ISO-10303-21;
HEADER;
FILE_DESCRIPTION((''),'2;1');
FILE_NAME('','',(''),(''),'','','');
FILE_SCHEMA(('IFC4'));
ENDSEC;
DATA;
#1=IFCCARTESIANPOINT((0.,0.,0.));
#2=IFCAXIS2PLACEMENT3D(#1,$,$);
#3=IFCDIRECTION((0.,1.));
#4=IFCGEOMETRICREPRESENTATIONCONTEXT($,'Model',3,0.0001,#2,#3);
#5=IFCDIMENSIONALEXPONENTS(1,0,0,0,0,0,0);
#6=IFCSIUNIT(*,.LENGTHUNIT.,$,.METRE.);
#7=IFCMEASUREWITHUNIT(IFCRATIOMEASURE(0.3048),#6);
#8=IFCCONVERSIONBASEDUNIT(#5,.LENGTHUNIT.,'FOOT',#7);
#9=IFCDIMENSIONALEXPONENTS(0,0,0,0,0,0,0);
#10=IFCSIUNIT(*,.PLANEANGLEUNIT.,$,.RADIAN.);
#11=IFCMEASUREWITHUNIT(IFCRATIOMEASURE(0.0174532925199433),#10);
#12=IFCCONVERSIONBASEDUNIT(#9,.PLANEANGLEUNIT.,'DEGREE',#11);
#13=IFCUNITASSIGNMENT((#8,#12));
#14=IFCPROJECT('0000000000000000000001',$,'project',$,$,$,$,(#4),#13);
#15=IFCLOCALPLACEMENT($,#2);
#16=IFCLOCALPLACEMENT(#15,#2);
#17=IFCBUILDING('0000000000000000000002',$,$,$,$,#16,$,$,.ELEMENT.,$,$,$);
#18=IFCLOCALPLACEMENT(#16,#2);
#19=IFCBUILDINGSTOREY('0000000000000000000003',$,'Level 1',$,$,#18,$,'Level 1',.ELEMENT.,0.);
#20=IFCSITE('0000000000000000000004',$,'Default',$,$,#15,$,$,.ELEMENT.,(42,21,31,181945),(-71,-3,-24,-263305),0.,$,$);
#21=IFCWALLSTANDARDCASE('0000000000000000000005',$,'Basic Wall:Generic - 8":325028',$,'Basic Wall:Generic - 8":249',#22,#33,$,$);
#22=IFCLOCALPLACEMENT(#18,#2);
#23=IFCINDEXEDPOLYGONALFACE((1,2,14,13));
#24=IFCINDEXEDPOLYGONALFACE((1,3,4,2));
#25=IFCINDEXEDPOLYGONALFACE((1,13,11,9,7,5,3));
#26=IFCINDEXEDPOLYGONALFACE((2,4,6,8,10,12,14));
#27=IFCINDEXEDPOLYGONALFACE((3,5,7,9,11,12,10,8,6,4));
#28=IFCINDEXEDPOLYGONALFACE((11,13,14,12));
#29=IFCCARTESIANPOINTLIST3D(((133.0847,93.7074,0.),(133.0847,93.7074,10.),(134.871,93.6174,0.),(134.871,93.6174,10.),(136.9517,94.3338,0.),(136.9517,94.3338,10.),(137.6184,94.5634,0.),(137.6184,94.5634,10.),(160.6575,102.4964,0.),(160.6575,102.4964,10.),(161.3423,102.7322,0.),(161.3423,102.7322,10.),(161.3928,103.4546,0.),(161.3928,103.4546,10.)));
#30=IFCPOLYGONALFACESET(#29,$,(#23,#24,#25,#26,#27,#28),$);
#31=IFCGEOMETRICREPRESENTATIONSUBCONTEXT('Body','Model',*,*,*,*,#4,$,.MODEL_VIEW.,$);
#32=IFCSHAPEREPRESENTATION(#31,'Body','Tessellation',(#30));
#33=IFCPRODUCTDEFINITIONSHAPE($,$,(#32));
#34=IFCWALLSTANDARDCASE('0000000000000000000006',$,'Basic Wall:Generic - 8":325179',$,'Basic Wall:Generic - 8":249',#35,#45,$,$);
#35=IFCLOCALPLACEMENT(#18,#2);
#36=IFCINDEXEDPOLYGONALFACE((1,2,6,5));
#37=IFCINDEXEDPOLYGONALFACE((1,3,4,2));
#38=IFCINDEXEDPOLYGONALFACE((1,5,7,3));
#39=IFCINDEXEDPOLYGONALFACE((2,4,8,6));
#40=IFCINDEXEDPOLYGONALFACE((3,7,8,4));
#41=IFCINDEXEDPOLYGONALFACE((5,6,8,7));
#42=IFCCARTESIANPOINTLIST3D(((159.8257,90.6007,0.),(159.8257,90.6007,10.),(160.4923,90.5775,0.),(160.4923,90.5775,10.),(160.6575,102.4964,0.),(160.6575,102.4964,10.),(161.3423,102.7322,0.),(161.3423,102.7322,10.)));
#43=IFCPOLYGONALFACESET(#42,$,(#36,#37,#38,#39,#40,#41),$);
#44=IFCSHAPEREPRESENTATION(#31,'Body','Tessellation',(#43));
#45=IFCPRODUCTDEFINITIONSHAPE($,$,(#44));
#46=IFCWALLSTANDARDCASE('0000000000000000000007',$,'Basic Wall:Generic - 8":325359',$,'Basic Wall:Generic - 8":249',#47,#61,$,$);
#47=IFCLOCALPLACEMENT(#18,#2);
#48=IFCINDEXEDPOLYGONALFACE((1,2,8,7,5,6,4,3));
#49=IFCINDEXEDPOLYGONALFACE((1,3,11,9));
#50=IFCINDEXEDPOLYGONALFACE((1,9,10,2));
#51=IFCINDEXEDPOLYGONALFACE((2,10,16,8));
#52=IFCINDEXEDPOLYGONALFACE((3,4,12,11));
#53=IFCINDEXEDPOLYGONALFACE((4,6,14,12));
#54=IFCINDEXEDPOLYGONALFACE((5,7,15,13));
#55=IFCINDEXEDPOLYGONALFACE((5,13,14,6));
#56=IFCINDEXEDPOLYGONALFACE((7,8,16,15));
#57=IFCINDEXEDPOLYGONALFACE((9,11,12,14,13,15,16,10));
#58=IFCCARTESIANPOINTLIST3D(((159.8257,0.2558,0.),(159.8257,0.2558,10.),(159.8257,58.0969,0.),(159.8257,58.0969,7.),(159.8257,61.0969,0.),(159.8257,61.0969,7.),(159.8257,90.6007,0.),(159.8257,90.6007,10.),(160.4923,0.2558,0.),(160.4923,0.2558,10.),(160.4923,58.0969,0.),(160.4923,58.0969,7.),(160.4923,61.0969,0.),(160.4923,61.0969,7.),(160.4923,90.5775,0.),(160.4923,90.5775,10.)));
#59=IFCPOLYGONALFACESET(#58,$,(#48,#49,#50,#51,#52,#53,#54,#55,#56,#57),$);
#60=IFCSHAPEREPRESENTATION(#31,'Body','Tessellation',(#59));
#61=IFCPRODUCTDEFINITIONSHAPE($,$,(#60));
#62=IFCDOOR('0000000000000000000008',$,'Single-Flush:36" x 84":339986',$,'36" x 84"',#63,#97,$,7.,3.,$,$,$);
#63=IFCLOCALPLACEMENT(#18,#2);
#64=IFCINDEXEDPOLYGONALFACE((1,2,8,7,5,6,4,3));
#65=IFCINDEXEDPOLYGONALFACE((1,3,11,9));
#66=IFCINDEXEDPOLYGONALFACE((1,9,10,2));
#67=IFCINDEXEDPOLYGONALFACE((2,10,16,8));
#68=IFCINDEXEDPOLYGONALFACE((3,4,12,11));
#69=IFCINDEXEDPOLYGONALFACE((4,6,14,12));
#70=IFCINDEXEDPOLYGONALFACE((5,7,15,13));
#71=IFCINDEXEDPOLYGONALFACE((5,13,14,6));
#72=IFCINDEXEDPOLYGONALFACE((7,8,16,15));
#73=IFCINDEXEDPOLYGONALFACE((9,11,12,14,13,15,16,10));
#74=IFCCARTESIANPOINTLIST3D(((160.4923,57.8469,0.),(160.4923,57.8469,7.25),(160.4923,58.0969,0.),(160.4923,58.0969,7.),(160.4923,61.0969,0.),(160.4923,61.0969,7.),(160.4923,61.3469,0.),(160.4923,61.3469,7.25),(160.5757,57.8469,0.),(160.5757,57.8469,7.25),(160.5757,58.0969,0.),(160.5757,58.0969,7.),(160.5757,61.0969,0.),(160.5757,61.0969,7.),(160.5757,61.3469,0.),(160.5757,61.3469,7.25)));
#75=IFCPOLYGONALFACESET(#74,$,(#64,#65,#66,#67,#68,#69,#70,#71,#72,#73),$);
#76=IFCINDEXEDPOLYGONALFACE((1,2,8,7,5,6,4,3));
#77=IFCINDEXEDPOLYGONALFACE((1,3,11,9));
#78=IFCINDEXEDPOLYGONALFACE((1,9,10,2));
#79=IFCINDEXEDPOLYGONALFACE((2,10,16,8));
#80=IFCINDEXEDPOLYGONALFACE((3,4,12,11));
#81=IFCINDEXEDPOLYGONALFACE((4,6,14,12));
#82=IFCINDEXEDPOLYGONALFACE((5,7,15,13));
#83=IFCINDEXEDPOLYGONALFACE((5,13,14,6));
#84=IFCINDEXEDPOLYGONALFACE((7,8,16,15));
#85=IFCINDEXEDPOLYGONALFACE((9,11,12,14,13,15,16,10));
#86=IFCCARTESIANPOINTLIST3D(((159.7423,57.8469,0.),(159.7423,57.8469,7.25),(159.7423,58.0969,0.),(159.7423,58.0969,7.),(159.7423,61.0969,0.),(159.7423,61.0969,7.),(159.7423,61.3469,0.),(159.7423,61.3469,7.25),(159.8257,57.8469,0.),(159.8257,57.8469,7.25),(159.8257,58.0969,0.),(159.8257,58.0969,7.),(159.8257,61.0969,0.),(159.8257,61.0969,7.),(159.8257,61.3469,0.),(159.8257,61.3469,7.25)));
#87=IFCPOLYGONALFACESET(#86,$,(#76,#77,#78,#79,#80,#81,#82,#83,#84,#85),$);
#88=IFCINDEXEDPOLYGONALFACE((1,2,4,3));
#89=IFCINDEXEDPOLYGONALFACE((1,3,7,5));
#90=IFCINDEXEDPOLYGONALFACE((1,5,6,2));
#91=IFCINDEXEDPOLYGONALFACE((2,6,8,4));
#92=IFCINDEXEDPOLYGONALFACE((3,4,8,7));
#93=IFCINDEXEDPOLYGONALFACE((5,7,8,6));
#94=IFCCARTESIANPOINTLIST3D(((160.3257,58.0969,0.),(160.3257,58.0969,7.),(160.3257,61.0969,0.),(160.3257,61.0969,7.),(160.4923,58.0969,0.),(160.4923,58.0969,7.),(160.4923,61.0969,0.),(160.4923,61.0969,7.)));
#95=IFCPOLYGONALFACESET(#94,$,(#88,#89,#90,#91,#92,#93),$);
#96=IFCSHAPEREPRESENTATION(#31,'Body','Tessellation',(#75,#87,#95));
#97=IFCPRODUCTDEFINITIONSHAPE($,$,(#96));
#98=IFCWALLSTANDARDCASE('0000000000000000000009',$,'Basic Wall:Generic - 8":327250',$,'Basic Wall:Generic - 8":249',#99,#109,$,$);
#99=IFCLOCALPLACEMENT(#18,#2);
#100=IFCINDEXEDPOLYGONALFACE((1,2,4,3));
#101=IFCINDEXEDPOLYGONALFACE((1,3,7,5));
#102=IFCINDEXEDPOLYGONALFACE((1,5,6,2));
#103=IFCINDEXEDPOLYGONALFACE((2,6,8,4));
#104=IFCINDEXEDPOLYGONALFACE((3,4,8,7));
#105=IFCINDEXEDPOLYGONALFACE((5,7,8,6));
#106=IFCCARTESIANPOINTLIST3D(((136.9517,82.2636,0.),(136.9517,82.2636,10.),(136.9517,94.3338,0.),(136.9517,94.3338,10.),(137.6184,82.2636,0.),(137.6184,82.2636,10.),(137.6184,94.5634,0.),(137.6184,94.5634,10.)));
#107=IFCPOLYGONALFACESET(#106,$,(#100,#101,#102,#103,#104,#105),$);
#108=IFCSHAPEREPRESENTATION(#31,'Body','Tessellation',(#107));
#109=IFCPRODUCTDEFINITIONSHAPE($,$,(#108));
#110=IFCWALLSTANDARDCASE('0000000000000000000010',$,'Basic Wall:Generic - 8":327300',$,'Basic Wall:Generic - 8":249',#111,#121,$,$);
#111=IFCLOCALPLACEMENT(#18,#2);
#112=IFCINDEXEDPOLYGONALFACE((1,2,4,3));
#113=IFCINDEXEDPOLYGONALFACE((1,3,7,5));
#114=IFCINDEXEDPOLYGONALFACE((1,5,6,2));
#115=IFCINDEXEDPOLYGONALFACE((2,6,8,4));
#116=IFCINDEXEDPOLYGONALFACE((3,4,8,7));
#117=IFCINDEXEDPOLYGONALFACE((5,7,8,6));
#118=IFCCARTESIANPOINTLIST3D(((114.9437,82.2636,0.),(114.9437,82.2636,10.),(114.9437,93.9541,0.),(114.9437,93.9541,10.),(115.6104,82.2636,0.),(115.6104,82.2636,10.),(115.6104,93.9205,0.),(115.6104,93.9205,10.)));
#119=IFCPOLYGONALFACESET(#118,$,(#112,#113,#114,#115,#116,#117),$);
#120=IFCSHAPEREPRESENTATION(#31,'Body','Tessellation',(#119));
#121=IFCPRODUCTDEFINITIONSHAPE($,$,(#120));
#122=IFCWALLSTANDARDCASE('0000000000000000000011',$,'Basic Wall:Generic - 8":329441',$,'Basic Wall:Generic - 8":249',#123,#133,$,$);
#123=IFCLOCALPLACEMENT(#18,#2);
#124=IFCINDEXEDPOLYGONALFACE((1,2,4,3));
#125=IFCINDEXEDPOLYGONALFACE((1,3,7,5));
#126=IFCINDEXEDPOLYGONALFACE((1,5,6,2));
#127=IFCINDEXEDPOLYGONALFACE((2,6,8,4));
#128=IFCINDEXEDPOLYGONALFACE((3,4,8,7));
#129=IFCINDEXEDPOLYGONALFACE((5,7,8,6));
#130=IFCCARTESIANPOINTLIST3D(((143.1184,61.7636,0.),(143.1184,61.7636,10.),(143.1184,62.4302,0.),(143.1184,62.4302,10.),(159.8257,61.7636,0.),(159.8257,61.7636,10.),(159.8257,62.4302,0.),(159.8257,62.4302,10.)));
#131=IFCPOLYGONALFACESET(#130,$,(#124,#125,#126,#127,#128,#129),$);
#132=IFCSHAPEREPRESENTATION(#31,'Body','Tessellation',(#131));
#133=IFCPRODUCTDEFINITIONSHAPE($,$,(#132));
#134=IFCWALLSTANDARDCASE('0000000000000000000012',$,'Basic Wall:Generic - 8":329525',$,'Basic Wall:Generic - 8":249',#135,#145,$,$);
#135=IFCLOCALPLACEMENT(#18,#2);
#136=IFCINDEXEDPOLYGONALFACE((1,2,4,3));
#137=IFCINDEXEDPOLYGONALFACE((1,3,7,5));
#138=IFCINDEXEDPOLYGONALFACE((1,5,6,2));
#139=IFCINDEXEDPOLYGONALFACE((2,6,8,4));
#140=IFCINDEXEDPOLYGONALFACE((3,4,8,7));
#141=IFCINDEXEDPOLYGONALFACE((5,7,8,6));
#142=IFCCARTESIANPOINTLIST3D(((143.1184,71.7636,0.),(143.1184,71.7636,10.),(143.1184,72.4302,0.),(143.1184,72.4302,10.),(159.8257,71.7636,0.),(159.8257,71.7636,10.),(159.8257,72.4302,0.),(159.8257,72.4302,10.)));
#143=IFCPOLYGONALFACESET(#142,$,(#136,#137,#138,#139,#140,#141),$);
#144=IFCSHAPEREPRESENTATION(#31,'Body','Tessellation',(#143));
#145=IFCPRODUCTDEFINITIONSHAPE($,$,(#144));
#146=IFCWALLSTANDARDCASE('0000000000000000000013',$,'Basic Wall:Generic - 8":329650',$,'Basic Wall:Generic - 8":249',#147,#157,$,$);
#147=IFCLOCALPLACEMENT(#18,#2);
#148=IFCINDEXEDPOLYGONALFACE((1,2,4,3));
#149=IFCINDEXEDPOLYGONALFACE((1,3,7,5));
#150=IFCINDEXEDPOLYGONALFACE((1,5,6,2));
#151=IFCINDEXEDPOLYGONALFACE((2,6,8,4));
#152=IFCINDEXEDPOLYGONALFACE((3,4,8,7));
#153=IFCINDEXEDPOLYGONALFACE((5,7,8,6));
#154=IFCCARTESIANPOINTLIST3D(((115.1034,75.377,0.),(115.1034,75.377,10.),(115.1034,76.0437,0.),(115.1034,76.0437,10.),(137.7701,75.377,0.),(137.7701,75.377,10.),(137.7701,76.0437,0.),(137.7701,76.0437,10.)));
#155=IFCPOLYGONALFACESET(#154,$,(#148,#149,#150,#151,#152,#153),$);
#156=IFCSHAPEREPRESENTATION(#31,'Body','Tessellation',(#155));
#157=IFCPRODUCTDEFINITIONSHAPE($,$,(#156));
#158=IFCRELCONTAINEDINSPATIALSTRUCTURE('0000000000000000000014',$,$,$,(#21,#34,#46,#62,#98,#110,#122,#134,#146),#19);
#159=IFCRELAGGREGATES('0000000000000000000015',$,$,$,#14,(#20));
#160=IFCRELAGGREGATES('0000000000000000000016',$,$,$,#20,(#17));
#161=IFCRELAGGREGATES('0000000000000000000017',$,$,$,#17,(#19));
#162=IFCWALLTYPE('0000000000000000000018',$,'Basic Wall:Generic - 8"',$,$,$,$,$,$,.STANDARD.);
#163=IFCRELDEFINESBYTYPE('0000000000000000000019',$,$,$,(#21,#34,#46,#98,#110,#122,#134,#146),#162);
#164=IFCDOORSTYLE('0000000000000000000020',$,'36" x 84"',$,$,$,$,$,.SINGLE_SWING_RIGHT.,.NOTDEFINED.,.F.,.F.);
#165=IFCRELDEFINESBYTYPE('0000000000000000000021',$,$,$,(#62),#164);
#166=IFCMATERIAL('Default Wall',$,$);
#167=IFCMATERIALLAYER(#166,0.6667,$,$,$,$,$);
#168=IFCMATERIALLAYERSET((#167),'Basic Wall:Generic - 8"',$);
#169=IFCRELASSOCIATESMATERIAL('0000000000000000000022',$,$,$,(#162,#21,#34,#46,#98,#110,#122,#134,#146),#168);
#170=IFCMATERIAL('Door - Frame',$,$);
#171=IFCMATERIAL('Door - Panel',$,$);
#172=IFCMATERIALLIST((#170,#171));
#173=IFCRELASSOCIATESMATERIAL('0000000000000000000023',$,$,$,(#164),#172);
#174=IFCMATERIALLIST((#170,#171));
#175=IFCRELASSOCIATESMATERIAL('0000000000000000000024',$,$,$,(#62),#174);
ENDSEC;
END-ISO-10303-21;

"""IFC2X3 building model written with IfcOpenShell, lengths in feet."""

from ifc_helpers import new_model, entity, si_unit, converted_unit, direction, frame, frame_2d, origin, place, context, subcontext, project, spatial, polyline, rectangle, outline, extrude, source, transform, mapped, material, material_list, layer, layer_set, layer_usage, type_object, type_shapes, element, fill, save


model = new_model("IFC2X3")

# Units and contexts
model_context = context("Model", 3, precision=0.0001, world=origin(), true_north=direction((0.0, 1.0)))
body_context = subcontext(model_context, "Body", "Model", "MODEL_VIEW")
ifc_project = project(units=[converted_unit("LENGTHUNIT", "FOOT", entity("IfcRatioMeasure", 0.3048), si_unit("LENGTHUNIT", "METRE"), dimensions=[1, 0, 0, 0, 0, 0, 0]), converted_unit("PLANEANGLEUNIT", "DEGREE", entity("IfcRatioMeasure", 0.0174532925199433), si_unit("PLANEANGLEUNIT", "RADIAN"), dimensions=[0, 0, 0, 0, 0, 0, 0])], contexts=[model_context])

# Site, building, storey
site_placement = place(None, origin())
site = spatial("IfcSite", under=ifc_project, at=site_placement, Name="Default", CompositionType="ELEMENT", RefLatitude=(42, 21, 31, 181945), RefLongitude=(-71, -3, -24, -263305), RefElevation=0.0)
building_placement = place(site_placement, origin())
building = spatial("IfcBuilding", under=site, at=building_placement, CompositionType="ELEMENT")
storey_placement = place(building_placement, origin())
storey = spatial("IfcBuildingStorey", under=building, at=storey_placement, Name="Level 1", LongName="Level 1", CompositionType="ELEMENT", Elevation=0.0)

# Walls
ifc_material_1 = material(Name="Default Wall")
ifc_layer = layer(ifc_material_1, 0.6667)
ifc_layer_set = layer_set([ifc_layer], Name="Basic Wall:Generic - 8\"")
ifc_layer_usage_1 = layer_usage(ifc_layer_set, "AXIS2", "NEGATIVE", 0.3333)
wall_type = type_object("IfcWallType", Name="Basic Wall:Generic - 8\"", PredefinedType="STANDARD", material=ifc_layer_set)
wall_1_placement = place(storey_placement, frame((133.1933, 93.3922, 0.0), z_axis=(0.0, 0.0, 1.0), x_axis=(0.945519, 0.325568, 0.0)))
element("IfcWallStandardCase", 1, at=wall_1_placement, inside=storey, type_object=wall_type, material=ifc_layer_usage_1, Name="Basic Wall:Generic - 8\":325028", ObjectType="Basic Wall:Generic - 8\":249", context=body_context, shape_type="SweptSolid", body=[
    extrude(outline(polyline([(29.6562, -0.3333), (29.9392, 0.3333), (0.0, 0.3333), (1.6596, -0.3333), (3.8603, -0.3333), (4.5653, -0.3333), (28.9319, -0.3333), (29.6562, -0.3333)])), origin(), (0.0, 0.0, 1.0), 10.0),
])
ifc_layer_usage_2 = layer_usage(ifc_layer_set, "AXIS2", "NEGATIVE", 0.3333)
wall_2_placement = place(storey_placement, frame((161.0097, 102.7554, 0.0), z_axis=(0.0, 0.0, 1.0), x_axis=(-0.069756, -0.997564, 0.0)))
element("IfcWallStandardCase", 2, at=wall_2_placement, inside=storey, type_object=wall_type, material=ifc_layer_usage_2, Name="Basic Wall:Generic - 8\":325179", ObjectType="Basic Wall:Generic - 8\":249", context=body_context, shape_type="SweptSolid", body=[
    extrude(outline(polyline([(12.2077, -0.3333), (12.1844, 0.3333), (0.0, 0.3333), (0.283, -0.3333), (12.2077, -0.3333)])), origin(), (0.0, 0.0, 1.0), 10.0),
])

# Wall, opening, door
ifc_layer_usage_3 = layer_usage(ifc_layer_set, "AXIS2", "NEGATIVE", 0.3333)
wall_3_placement = place(storey_placement, frame((160.159, 90.6007, 0.0), z_axis=(0.0, 0.0, 1.0), x_axis=(0.0, -1.0, 0.0)))
wall_3 = element("IfcWallStandardCase", 3, at=wall_3_placement, inside=storey, type_object=wall_type, material=ifc_layer_usage_3, Name="Basic Wall:Generic - 8\":325359", ObjectType="Basic Wall:Generic - 8\":249", context=body_context, shape_type="SweptSolid", body=[
    extrude(outline(polyline([(0.0, -0.3333), (8.3372, -0.3333), (9.0038, -0.3333), (18.1705, -0.3333), (18.8372, -0.3333), (28.1705, -0.3333), (28.8372, -0.3333), (32.9994, -0.3333), (33.666, -0.3333), (43.6705, -0.3333), (44.3372, -0.3333), (58.6705, -0.3333), (59.3372, -0.3333), (68.6705, -0.3333), (69.3372, -0.3333), (89.6783, -0.3333), (90.345, -0.3333), (90.345, 0.3333), (0.0233, 0.3333), (0.0, -0.3333)])), origin(), (0.0, 0.0, 1.0), 10.0),
])
opening_1_placement = place(wall_3_placement, frame((29.5038, -0.3333, 0.0)))
opening_1 = element("IfcOpeningElement", 4, at=opening_1_placement, cuts=wall_3, ObjectType="Opening", context=body_context, shape_type="SweptSolid", body=[
    extrude(rectangle(XDim=3.0, YDim=7.0, at=frame_2d((3.5, 1.5), x_axis=(0.0, 1.0))), frame((0.0, 0.0, 0.0), z_axis=(0.0, 1.0, 0.0), x_axis=(0.0, 0.0, 1.0)), (0.0, 0.0, 1.0), 0.6667),
])
ifc_material_2 = material(Name="Door - Frame")
ifc_material_3 = material(Name="Door - Panel")
ifc_material_list_1 = material_list([ifc_material_2, ifc_material_3])
ifc_material_list_2 = material_list([ifc_material_2, ifc_material_3])
door_style_1 = type_object("IfcDoorStyle", Name="36\" x 84\"", ConstructionType="NOTDEFINED", OperationType="SINGLE_SWING_RIGHT", ParameterTakesPrecedence=False, Sizeable=False, material=ifc_material_list_2)
shared_shape_1 = source(origin(), body_context, "Body", "SweptSolid", [
    extrude(outline(polyline([(-1.75, -3.6875), (1.75, -3.6875), (1.75, 3.5625), (1.5, 3.5625), (1.5, -3.4375), (-1.5, -3.4375), (-1.5, 3.5625), (-1.75, 3.5625), (-1.75, -3.6875)])), frame((1.5, 0.6667, 3.5625), z_axis=(0.0, 1.0, 0.0), x_axis=(1.0, 0.0, 0.0)), (0.0, 0.0, 1.0), 0.0833),
    extrude(outline(polyline([(-3.6875, -1.75), (3.5625, -1.75), (3.5625, -1.5), (-3.4375, -1.5), (-3.4375, 1.5), (3.5625, 1.5), (3.5625, 1.75), (-3.6875, 1.75), (-3.6875, -1.75)])), frame((1.5, -0.0833, 3.5625), z_axis=(0.0, 1.0, 0.0), x_axis=(0.0, 0.0, -1.0)), (0.0, 0.0, 1.0), 0.0833),
    extrude(rectangle(XDim=0.1667, YDim=3.0, at=frame_2d((0.0, 0.0), x_axis=(1.0, 0.0))), frame((1.5, 0.5833, 0.0), z_axis=(0.0, 0.0, 1.0), x_axis=(0.0, 1.0, 0.0)), (0.0, 0.0, 1.0), 7.0),
])
type_shapes(door_style_1, [shared_shape_1])
door_1_placement = place(opening_1_placement, origin())
door_1 = element("IfcDoor", 5, at=door_1_placement, inside=storey, type_object=door_style_1, material=ifc_material_list_1, Name="Single-Flush:36\" x 84\":339986", ObjectType="36\" x 84\"", OverallHeight=7.0, OverallWidth=3.0, context=body_context, shape_type="MappedRepresentation", body=[
    mapped(shared_shape_1, transform((0.0, 0.0, 0.0), scale=1.0)),
])
fill(opening_1, door_1)

# Walls
ifc_layer_usage_4 = layer_usage(ifc_layer_set, "AXIS2", "NEGATIVE", 0.3333)
wall_4_placement = place(storey_placement, frame((137.2851, 94.5634, 0.0), z_axis=(0.0, 0.0, 1.0), x_axis=(0.0, -1.0, 0.0)))
element("IfcWallStandardCase", 6, at=wall_4_placement, inside=storey, type_object=wall_type, material=ifc_layer_usage_4, Name="Basic Wall:Generic - 8\":327250", ObjectType="Basic Wall:Generic - 8\":249", context=body_context, shape_type="SweptSolid", body=[
    extrude(outline(polyline([(12.2998, -0.3333), (12.2998, 0.3333), (0.0, 0.3333), (0.2296, -0.3333), (12.2998, -0.3333)])), origin(), (0.0, 0.0, 1.0), 10.0),
])
ifc_layer_usage_5 = layer_usage(ifc_layer_set, "AXIS2", "NEGATIVE", 0.3333)
wall_5_placement = place(storey_placement, frame((115.277, 93.9541, 0.0), z_axis=(0.0, 0.0, 1.0), x_axis=(0.0, -1.0, 0.0)))
element("IfcWallStandardCase", 7, at=wall_5_placement, inside=storey, type_object=wall_type, material=ifc_layer_usage_5, Name="Basic Wall:Generic - 8\":327300", ObjectType="Basic Wall:Generic - 8\":249", context=body_context, shape_type="SweptSolid", body=[
    extrude(outline(polyline([(11.6906, -0.3333), (11.6906, 0.3333), (0.0336, 0.3333), (0.0, -0.3333), (11.6906, -0.3333)])), origin(), (0.0, 0.0, 1.0), 10.0),
])

# Walls
ifc_layer_usage_6 = layer_usage(ifc_layer_set, "AXIS2", "NEGATIVE", 0.3333)
wall_6_placement = place(storey_placement, frame((143.1184, 62.0969, 0.0)))
element("IfcWallStandardCase", 8, at=wall_6_placement, inside=storey, type_object=wall_type, material=ifc_layer_usage_6, Name="Basic Wall:Generic - 8\":329441", ObjectType="Basic Wall:Generic - 8\":249", context=body_context, shape_type="SweptSolid", body=[
    extrude(rectangle(XDim=16.7072, YDim=0.6667, at=frame_2d((8.3536, 0.0), x_axis=(-1.0, 0.0))), origin(), (0.0, 0.0, 1.0), 10.0),
])
ifc_layer_usage_7 = layer_usage(ifc_layer_set, "AXIS2", "NEGATIVE", 0.3333)
wall_7_placement = place(storey_placement, frame((143.1184, 72.0969, 0.0)))
element("IfcWallStandardCase", 9, at=wall_7_placement, inside=storey, type_object=wall_type, material=ifc_layer_usage_7, Name="Basic Wall:Generic - 8\":329525", ObjectType="Basic Wall:Generic - 8\":249", context=body_context, shape_type="SweptSolid", body=[
    extrude(rectangle(XDim=16.7072, YDim=0.6667, at=frame_2d((8.3536, 0.0), x_axis=(-1.0, 0.0))), origin(), (0.0, 0.0, 1.0), 10.0),
])
ifc_layer_usage_8 = layer_usage(ifc_layer_set, "AXIS2", "NEGATIVE", 0.3333)
wall_8_placement = place(storey_placement, frame((115.1034, 75.7104, 0.0)))
element("IfcWallStandardCase", 10, at=wall_8_placement, inside=storey, type_object=wall_type, material=ifc_layer_usage_8, Name="Basic Wall:Generic - 8\":329650", ObjectType="Basic Wall:Generic - 8\":249", context=body_context, shape_type="SweptSolid", body=[
    extrude(rectangle(XDim=22.6667, YDim=0.6667, at=frame_2d((11.3333, 0.0), x_axis=(-1.0, 0.0))), origin(), (0.0, 0.0, 1.0), 10.0),
])

save(model, "model.ifc")
